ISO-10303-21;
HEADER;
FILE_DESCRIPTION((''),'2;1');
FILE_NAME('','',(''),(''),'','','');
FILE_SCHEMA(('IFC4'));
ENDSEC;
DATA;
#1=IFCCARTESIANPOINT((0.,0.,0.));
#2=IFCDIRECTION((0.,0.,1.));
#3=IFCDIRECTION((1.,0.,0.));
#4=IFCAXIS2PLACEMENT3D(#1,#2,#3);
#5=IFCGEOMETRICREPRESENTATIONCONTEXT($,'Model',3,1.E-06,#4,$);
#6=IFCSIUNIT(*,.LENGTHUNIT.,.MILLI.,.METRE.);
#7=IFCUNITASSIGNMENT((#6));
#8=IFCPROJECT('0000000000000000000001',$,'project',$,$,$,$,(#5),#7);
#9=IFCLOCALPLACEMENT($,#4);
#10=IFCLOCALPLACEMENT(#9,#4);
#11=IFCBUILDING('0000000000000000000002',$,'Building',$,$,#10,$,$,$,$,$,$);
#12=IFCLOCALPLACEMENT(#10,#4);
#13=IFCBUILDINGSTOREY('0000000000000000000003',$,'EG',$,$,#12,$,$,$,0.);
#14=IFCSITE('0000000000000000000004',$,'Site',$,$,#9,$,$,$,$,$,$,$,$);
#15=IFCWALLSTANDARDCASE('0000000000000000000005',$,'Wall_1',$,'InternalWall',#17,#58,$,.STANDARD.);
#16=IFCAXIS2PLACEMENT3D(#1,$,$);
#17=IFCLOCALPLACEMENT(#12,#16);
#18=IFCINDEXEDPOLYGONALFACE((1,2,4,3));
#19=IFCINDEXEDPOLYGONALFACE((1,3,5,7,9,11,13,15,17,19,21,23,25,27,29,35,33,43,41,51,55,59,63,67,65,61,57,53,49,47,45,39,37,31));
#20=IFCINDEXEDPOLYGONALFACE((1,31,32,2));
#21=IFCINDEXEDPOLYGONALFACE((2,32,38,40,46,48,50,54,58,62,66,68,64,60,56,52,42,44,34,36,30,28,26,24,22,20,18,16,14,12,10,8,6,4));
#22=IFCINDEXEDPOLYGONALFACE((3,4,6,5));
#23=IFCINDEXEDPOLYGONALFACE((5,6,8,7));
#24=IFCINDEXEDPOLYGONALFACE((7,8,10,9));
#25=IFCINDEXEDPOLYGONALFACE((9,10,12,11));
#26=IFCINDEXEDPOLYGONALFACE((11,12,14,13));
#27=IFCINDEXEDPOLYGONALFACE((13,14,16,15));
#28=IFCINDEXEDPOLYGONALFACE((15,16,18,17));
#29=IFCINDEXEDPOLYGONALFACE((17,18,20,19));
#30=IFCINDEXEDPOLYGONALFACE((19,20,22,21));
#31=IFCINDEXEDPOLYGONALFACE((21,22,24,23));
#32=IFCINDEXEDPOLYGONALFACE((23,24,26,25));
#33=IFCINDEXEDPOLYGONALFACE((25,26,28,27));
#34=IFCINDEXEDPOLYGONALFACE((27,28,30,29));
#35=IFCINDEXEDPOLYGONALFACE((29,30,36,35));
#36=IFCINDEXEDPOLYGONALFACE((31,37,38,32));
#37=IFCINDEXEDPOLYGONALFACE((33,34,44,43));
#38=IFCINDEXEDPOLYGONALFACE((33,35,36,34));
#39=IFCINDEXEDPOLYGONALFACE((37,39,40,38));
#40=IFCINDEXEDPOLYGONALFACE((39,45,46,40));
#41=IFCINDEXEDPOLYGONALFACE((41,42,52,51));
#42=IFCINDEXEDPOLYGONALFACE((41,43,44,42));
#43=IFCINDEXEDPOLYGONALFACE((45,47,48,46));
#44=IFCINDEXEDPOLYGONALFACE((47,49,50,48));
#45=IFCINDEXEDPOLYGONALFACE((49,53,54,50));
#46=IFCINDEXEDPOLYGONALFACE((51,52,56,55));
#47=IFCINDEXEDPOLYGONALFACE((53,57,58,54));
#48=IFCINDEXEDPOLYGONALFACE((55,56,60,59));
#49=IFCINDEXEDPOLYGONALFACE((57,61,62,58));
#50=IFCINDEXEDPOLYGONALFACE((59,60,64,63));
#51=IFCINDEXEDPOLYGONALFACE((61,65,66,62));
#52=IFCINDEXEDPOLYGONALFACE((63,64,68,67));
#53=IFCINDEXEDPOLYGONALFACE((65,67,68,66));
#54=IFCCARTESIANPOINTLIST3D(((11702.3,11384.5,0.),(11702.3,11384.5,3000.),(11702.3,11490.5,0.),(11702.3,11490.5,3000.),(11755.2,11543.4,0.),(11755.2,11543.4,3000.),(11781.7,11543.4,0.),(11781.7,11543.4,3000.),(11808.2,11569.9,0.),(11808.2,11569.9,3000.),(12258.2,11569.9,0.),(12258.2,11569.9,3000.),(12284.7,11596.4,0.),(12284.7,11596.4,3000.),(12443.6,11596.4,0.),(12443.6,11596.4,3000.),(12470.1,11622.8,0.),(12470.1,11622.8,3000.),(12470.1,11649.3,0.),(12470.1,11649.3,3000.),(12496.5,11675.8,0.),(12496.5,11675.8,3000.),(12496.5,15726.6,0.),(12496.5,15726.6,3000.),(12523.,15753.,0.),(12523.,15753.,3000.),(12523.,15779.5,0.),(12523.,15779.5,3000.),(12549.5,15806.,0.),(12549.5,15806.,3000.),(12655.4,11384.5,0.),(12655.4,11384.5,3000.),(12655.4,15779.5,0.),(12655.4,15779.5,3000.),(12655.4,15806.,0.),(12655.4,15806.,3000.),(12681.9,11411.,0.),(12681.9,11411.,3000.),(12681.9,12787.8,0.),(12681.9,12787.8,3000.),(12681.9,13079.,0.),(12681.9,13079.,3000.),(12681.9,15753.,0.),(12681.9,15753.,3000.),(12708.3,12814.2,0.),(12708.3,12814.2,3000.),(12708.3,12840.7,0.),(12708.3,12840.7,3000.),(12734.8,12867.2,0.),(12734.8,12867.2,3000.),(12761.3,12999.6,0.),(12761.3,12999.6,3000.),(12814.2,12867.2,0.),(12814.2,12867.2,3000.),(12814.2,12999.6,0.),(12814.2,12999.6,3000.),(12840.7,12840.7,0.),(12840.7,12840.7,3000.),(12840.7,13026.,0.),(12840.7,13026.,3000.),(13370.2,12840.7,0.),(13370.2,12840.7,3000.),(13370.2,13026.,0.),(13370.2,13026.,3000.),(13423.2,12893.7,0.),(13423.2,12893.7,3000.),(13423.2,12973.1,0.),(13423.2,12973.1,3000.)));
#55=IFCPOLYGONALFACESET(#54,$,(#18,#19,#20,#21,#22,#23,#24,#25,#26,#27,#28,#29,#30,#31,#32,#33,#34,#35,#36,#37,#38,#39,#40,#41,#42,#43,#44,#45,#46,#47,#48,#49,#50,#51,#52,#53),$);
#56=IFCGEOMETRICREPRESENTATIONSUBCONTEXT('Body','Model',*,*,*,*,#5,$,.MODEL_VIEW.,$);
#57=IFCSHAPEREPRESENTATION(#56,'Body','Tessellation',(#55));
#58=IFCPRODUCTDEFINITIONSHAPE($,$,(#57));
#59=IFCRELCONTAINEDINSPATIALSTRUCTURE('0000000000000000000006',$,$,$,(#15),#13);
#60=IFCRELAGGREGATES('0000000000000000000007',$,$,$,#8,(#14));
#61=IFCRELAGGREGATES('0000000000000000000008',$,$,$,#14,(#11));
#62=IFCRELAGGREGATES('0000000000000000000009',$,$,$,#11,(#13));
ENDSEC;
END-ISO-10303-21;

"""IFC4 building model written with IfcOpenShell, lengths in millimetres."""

from ifc_helpers import new_model, si_unit, frame, origin_with_axes, place, context, subcontext, project, spatial, polyline, rectangle, outline, extrude, element, save


model = new_model("IFC4")

# Units and contexts
model_context = context("Model", 3, precision=1e-06, world=origin_with_axes())
body_context = subcontext(model_context, "Body", "Model", "MODEL_VIEW")
ifc_project = project(units=[si_unit("LENGTHUNIT", "METRE", prefix="MILLI")], contexts=[model_context])

# Site, building, storey
site_placement = place(None, origin_with_axes())
site = spatial("IfcSite", under=ifc_project, at=site_placement, Name="Site")
building_placement = place(site_placement, origin_with_axes())
building = spatial("IfcBuilding", under=site, at=building_placement, Name="Building")
storey_placement = place(building_placement, origin_with_axes())
storey = spatial("IfcBuildingStorey", under=building, at=storey_placement, Name="EG", Elevation=0.0)

# Wall, opening
wall_1_placement = place(storey_placement, origin_with_axes())
wall_1 = element("IfcWallStandardCase", 1, at=wall_1_placement, inside=storey, Name="Wall_1", ObjectType="InternalWall", PredefinedType="STANDARD", context=body_context, shape_type="SweptSolid", body=[
    extrude(outline(polyline([(11702.3, 11384.5, 0.0), (11702.3, 11490.5, 0.0), (11755.2, 11543.4, 0.0), (11781.7, 11543.4, 0.0), (11808.2, 11569.9, 0.0), (12258.2, 11569.9, 0.0), (12284.7, 11596.4, 0.0), (12443.6, 11596.4, 0.0), (12470.1, 11622.8, 0.0), (12470.1, 11649.3, 0.0), (12496.5, 11675.8, 0.0), (12496.5, 15726.6, 0.0), (12523.0, 15753.0, 0.0), (12523.0, 15779.5, 0.0), (12549.5, 15806.0, 0.0), (12655.4, 15806.0, 0.0), (12655.4, 15779.5, 0.0), (12681.9, 15753.0, 0.0), (12681.9, 13079.0, 0.0), (12761.3, 12999.6, 0.0), (12814.2, 12999.6, 0.0), (12840.7, 13026.0, 0.0), (13370.2, 13026.0, 0.0), (13423.2, 12973.1, 0.0), (13423.2, 12893.7, 0.0), (13370.2, 12840.7, 0.0), (12840.7, 12840.7, 0.0), (12814.2, 12867.2, 0.0), (12734.8, 12867.2, 0.0), (12708.3, 12840.7, 0.0), (12708.3, 12814.2, 0.0), (12681.9, 12787.8, 0.0), (12681.9, 11411.0, 0.0), (12655.4, 11384.5, 0.0), (11702.3, 11384.5, 0.0)])), origin_with_axes(), (0.0, 0.0, 1.0), 3000.0),
])
opening_placement = place(wall_1_placement, origin_with_axes())
element("IfcOpeningElement", 2, at=opening_placement, inside=storey, cuts=wall_1, context=body_context, shape_type="SweptSolid", body=[
    extrude(rectangle(XDim=873.7, YDim=240.0), frame((11261.9, 11473.4, 0.0), z_axis=(0.0, 0.0, 1.0), x_axis=(1.0, 0.0, 0.0)), (0.0, 0.0, 1.0), 2100.0),
])

save(model, "model.ifc")
